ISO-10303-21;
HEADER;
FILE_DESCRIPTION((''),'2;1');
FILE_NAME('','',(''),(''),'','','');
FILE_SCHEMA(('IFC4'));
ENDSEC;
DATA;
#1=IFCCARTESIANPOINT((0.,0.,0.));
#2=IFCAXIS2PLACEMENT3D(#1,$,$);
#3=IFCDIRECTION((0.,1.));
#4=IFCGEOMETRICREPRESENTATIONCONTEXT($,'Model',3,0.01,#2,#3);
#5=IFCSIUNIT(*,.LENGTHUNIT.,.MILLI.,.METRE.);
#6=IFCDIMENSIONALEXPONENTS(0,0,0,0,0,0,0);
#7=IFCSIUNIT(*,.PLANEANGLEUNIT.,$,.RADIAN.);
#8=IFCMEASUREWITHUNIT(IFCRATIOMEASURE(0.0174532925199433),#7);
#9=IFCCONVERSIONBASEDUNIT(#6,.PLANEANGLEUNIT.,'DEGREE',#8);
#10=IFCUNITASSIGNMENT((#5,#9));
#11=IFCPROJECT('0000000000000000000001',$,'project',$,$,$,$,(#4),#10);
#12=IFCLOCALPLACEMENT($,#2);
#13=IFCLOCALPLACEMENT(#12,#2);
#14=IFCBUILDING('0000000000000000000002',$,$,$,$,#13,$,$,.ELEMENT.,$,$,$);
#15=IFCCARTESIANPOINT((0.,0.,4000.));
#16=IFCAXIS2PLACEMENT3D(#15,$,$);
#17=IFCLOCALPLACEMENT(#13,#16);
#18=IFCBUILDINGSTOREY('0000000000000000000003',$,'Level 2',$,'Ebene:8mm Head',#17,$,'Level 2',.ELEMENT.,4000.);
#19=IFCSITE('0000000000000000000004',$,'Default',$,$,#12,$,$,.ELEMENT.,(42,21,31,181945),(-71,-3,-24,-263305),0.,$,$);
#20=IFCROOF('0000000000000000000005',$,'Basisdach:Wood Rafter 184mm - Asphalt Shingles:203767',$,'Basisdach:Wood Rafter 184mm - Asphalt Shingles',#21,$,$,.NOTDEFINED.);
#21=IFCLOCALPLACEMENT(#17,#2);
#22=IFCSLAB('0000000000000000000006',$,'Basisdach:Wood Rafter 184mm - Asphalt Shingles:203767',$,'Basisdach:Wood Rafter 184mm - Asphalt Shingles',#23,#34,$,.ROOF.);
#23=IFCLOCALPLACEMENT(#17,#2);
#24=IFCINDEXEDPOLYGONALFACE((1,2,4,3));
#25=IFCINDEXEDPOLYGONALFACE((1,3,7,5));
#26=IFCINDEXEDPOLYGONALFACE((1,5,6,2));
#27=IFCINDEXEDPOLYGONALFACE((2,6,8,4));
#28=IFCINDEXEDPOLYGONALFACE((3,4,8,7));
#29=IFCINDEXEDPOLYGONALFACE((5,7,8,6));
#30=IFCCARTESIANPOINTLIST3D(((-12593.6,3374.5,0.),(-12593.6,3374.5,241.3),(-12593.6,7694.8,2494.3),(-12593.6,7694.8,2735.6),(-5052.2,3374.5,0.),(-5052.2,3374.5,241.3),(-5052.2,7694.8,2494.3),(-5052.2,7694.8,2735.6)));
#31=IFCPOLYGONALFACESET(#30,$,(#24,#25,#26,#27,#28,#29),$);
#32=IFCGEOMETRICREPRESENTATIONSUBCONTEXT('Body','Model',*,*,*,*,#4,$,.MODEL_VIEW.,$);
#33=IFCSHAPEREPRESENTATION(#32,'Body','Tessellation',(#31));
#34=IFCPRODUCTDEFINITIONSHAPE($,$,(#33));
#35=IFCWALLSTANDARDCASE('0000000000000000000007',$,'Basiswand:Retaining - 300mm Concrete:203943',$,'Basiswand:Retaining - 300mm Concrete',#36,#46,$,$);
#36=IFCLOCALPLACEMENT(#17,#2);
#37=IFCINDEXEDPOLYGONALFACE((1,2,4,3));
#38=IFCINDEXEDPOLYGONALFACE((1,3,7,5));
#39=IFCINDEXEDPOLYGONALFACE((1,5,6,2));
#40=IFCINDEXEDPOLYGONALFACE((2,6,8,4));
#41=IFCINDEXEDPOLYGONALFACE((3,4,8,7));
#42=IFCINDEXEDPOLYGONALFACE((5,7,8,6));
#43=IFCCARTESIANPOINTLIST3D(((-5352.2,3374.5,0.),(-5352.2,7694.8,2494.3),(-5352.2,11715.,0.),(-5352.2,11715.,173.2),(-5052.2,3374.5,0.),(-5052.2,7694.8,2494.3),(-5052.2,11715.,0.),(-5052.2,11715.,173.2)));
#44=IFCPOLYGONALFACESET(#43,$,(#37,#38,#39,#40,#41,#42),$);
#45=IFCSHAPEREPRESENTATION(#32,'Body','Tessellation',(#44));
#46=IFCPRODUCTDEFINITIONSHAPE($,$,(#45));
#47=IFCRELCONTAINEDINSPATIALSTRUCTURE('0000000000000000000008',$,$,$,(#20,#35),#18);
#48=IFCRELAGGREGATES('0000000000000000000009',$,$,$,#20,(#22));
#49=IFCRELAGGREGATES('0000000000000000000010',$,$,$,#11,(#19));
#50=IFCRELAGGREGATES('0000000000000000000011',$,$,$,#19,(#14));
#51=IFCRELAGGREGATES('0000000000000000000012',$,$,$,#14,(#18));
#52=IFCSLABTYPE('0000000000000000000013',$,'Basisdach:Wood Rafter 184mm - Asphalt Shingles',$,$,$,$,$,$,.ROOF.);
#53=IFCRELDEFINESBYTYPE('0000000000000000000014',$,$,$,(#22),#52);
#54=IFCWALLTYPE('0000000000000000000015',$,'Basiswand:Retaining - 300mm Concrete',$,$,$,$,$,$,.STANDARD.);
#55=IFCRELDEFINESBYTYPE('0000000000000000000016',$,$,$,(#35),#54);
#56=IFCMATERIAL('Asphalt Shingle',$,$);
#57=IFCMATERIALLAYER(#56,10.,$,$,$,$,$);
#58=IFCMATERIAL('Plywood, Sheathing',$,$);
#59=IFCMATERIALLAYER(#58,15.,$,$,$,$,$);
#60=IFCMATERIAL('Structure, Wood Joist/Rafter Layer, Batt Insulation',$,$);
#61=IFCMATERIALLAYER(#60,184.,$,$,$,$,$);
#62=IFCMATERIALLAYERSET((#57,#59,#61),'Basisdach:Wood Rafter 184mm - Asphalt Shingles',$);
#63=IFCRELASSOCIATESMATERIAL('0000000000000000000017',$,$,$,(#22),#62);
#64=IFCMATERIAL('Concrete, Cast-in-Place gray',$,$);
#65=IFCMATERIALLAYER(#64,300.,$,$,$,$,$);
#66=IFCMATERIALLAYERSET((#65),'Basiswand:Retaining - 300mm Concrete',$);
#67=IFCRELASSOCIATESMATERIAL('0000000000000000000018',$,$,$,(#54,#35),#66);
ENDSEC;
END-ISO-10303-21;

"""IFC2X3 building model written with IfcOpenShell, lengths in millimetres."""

from ifc_helpers import new_model, entity, si_unit, converted_unit, direction, frame, frame_2d, origin, place, context, subcontext, project, spatial, polyline, rectangle, extrude, clip, bounded_halfspace, material, layer, layer_set, layer_usage, type_object, element, aggregate, save


model = new_model("IFC2X3")

# Units and contexts
model_context = context("Model", 3, precision=0.01, world=origin(), true_north=direction((0.0, 1.0)))
body_context = subcontext(model_context, "Body", "Model", "MODEL_VIEW")
ifc_project = project(units=[si_unit("LENGTHUNIT", "METRE", prefix="MILLI"), converted_unit("PLANEANGLEUNIT", "DEGREE", entity("IfcRatioMeasure", 0.0174532925199433), si_unit("PLANEANGLEUNIT", "RADIAN"), dimensions=[0, 0, 0, 0, 0, 0, 0])], contexts=[model_context])

# Site, building, storey
site_placement = place(None, origin())
site = spatial("IfcSite", under=ifc_project, at=site_placement, Name="Default", CompositionType="ELEMENT", RefLatitude=(42, 21, 31, 181945), RefLongitude=(-71, -3, -24, -263305), RefElevation=0.0)
building_placement = place(site_placement, origin())
building = spatial("IfcBuilding", under=site, at=building_placement, CompositionType="ELEMENT")
storey_placement = place(building_placement, frame((0.0, 0.0, 4000.0)))
storey = spatial("IfcBuildingStorey", under=building, at=storey_placement, Name="Level 2", ObjectType="Ebene:8mm Head", LongName="Level 2", CompositionType="ELEMENT", Elevation=4000.0)

# Roof, slab
roof_placement = place(storey_placement, frame((-12593.6, 3374.5, 0.0)))
roof = element("IfcRoof", 1, at=roof_placement, inside=storey, Name="Basisdach:Wood Rafter 184mm - Asphalt Shingles:203767", ObjectType="Basisdach:Wood Rafter 184mm - Asphalt Shingles", ShapeType="NOTDEFINED")
ifc_material_1 = material(Name="Asphalt Shingle")
ifc_layer_1 = layer(ifc_material_1, 10.0)
ifc_material_2 = material(Name="Plywood, Sheathing")
ifc_layer_2 = layer(ifc_material_2, 15.0)
ifc_material_3 = material(Name="Structure, Wood Joist/Rafter Layer, Batt Insulation")
ifc_layer_3 = layer(ifc_material_3, 184.0)
ifc_layer_set_1 = layer_set([ifc_layer_1, ifc_layer_2, ifc_layer_3], Name="Basisdach:Wood Rafter 184mm - Asphalt Shingles")
slab_type_1 = type_object("IfcSlabType", Name="Basisdach:Wood Rafter 184mm - Asphalt Shingles", PredefinedType="ROOF")
slab_1_placement = place(roof_placement, origin())
slab_1 = element("IfcSlab", 2, at=slab_1_placement, type_object=slab_type_1, material=ifc_layer_set_1, Name="Basisdach:Wood Rafter 184mm - Asphalt Shingles:203767", ObjectType="Basisdach:Wood Rafter 184mm - Asphalt Shingles", PredefinedType="ROOF", context=body_context, shape_type="SweptSolid", body=[
    extrude(rectangle(XDim=4988.6, YDim=7541.4, at=frame_2d((0.0, 0.0), x_axis=(0.0, 1.0))), frame((3770.7, 2160.1, 1247.1), z_axis=(0.0, -0.5, 0.866025), x_axis=(1.0, 0.0, 0.0)), (0.0, 0.5, 0.866025), 241.3),
])
aggregate(roof, [slab_1])

# Wall
ifc_material_4 = material(Name="Concrete, Cast-in-Place gray")
ifc_layer_4 = layer(ifc_material_4, 300.0)
ifc_layer_set_2 = layer_set([ifc_layer_4], Name="Basiswand:Retaining - 300mm Concrete")
ifc_layer_usage = layer_usage(ifc_layer_set_2, "AXIS2", "NEGATIVE", 150.0)
wall_type = type_object("IfcWallType", Name="Basiswand:Retaining - 300mm Concrete", PredefinedType="STANDARD", material=ifc_layer_set_2)
wall_placement = place(storey_placement, frame((-5202.2, 11715.0, 0.0), z_axis=(0.0, 0.0, 1.0), x_axis=(0.0, -1.0, 0.0)))
element("IfcWallStandardCase", 3, at=wall_placement, inside=storey, type_object=wall_type, material=ifc_layer_usage, Name="Basiswand:Retaining - 300mm Concrete:203943", ObjectType="Basiswand:Retaining - 300mm Concrete", context=body_context, shape_type="Clipping", body=[
    clip(clip(extrude(rectangle(XDim=8340.5, YDim=300.0, at=frame_2d((4170.3, 0.0), x_axis=(-1.0, 0.0))), origin(), (0.0, 0.0, 1.0), 2494.3), bounded_halfspace(frame((4020.3, -150.0, 2494.3), z_axis=(0.5, 0.0, 0.866025), x_axis=(0.0, 1.0, 0.0)), False, frame((4020.3, -150.0, 2494.3)), polyline([(0.0, 0.0), (4320.3, 0.0), (4320.3, 300.0), (746.0, 300.0), (0.0, 300.0), (0.0, 0.0)]))), bounded_halfspace(frame((0.0, -150.0, 173.2), z_axis=(-0.5, 0.0, 0.866025), x_axis=(0.0, -1.0, 0.0)), False, frame((0.0, -150.0, 173.2)), polyline([(0.0, 0.0), (4020.3, 0.0), (4020.3, 300.0), (2442.1, 300.0), (2233.1, 300.0), (0.0, 300.0), (0.0, 0.0)]))),
])

save(model, "model.ifc")
